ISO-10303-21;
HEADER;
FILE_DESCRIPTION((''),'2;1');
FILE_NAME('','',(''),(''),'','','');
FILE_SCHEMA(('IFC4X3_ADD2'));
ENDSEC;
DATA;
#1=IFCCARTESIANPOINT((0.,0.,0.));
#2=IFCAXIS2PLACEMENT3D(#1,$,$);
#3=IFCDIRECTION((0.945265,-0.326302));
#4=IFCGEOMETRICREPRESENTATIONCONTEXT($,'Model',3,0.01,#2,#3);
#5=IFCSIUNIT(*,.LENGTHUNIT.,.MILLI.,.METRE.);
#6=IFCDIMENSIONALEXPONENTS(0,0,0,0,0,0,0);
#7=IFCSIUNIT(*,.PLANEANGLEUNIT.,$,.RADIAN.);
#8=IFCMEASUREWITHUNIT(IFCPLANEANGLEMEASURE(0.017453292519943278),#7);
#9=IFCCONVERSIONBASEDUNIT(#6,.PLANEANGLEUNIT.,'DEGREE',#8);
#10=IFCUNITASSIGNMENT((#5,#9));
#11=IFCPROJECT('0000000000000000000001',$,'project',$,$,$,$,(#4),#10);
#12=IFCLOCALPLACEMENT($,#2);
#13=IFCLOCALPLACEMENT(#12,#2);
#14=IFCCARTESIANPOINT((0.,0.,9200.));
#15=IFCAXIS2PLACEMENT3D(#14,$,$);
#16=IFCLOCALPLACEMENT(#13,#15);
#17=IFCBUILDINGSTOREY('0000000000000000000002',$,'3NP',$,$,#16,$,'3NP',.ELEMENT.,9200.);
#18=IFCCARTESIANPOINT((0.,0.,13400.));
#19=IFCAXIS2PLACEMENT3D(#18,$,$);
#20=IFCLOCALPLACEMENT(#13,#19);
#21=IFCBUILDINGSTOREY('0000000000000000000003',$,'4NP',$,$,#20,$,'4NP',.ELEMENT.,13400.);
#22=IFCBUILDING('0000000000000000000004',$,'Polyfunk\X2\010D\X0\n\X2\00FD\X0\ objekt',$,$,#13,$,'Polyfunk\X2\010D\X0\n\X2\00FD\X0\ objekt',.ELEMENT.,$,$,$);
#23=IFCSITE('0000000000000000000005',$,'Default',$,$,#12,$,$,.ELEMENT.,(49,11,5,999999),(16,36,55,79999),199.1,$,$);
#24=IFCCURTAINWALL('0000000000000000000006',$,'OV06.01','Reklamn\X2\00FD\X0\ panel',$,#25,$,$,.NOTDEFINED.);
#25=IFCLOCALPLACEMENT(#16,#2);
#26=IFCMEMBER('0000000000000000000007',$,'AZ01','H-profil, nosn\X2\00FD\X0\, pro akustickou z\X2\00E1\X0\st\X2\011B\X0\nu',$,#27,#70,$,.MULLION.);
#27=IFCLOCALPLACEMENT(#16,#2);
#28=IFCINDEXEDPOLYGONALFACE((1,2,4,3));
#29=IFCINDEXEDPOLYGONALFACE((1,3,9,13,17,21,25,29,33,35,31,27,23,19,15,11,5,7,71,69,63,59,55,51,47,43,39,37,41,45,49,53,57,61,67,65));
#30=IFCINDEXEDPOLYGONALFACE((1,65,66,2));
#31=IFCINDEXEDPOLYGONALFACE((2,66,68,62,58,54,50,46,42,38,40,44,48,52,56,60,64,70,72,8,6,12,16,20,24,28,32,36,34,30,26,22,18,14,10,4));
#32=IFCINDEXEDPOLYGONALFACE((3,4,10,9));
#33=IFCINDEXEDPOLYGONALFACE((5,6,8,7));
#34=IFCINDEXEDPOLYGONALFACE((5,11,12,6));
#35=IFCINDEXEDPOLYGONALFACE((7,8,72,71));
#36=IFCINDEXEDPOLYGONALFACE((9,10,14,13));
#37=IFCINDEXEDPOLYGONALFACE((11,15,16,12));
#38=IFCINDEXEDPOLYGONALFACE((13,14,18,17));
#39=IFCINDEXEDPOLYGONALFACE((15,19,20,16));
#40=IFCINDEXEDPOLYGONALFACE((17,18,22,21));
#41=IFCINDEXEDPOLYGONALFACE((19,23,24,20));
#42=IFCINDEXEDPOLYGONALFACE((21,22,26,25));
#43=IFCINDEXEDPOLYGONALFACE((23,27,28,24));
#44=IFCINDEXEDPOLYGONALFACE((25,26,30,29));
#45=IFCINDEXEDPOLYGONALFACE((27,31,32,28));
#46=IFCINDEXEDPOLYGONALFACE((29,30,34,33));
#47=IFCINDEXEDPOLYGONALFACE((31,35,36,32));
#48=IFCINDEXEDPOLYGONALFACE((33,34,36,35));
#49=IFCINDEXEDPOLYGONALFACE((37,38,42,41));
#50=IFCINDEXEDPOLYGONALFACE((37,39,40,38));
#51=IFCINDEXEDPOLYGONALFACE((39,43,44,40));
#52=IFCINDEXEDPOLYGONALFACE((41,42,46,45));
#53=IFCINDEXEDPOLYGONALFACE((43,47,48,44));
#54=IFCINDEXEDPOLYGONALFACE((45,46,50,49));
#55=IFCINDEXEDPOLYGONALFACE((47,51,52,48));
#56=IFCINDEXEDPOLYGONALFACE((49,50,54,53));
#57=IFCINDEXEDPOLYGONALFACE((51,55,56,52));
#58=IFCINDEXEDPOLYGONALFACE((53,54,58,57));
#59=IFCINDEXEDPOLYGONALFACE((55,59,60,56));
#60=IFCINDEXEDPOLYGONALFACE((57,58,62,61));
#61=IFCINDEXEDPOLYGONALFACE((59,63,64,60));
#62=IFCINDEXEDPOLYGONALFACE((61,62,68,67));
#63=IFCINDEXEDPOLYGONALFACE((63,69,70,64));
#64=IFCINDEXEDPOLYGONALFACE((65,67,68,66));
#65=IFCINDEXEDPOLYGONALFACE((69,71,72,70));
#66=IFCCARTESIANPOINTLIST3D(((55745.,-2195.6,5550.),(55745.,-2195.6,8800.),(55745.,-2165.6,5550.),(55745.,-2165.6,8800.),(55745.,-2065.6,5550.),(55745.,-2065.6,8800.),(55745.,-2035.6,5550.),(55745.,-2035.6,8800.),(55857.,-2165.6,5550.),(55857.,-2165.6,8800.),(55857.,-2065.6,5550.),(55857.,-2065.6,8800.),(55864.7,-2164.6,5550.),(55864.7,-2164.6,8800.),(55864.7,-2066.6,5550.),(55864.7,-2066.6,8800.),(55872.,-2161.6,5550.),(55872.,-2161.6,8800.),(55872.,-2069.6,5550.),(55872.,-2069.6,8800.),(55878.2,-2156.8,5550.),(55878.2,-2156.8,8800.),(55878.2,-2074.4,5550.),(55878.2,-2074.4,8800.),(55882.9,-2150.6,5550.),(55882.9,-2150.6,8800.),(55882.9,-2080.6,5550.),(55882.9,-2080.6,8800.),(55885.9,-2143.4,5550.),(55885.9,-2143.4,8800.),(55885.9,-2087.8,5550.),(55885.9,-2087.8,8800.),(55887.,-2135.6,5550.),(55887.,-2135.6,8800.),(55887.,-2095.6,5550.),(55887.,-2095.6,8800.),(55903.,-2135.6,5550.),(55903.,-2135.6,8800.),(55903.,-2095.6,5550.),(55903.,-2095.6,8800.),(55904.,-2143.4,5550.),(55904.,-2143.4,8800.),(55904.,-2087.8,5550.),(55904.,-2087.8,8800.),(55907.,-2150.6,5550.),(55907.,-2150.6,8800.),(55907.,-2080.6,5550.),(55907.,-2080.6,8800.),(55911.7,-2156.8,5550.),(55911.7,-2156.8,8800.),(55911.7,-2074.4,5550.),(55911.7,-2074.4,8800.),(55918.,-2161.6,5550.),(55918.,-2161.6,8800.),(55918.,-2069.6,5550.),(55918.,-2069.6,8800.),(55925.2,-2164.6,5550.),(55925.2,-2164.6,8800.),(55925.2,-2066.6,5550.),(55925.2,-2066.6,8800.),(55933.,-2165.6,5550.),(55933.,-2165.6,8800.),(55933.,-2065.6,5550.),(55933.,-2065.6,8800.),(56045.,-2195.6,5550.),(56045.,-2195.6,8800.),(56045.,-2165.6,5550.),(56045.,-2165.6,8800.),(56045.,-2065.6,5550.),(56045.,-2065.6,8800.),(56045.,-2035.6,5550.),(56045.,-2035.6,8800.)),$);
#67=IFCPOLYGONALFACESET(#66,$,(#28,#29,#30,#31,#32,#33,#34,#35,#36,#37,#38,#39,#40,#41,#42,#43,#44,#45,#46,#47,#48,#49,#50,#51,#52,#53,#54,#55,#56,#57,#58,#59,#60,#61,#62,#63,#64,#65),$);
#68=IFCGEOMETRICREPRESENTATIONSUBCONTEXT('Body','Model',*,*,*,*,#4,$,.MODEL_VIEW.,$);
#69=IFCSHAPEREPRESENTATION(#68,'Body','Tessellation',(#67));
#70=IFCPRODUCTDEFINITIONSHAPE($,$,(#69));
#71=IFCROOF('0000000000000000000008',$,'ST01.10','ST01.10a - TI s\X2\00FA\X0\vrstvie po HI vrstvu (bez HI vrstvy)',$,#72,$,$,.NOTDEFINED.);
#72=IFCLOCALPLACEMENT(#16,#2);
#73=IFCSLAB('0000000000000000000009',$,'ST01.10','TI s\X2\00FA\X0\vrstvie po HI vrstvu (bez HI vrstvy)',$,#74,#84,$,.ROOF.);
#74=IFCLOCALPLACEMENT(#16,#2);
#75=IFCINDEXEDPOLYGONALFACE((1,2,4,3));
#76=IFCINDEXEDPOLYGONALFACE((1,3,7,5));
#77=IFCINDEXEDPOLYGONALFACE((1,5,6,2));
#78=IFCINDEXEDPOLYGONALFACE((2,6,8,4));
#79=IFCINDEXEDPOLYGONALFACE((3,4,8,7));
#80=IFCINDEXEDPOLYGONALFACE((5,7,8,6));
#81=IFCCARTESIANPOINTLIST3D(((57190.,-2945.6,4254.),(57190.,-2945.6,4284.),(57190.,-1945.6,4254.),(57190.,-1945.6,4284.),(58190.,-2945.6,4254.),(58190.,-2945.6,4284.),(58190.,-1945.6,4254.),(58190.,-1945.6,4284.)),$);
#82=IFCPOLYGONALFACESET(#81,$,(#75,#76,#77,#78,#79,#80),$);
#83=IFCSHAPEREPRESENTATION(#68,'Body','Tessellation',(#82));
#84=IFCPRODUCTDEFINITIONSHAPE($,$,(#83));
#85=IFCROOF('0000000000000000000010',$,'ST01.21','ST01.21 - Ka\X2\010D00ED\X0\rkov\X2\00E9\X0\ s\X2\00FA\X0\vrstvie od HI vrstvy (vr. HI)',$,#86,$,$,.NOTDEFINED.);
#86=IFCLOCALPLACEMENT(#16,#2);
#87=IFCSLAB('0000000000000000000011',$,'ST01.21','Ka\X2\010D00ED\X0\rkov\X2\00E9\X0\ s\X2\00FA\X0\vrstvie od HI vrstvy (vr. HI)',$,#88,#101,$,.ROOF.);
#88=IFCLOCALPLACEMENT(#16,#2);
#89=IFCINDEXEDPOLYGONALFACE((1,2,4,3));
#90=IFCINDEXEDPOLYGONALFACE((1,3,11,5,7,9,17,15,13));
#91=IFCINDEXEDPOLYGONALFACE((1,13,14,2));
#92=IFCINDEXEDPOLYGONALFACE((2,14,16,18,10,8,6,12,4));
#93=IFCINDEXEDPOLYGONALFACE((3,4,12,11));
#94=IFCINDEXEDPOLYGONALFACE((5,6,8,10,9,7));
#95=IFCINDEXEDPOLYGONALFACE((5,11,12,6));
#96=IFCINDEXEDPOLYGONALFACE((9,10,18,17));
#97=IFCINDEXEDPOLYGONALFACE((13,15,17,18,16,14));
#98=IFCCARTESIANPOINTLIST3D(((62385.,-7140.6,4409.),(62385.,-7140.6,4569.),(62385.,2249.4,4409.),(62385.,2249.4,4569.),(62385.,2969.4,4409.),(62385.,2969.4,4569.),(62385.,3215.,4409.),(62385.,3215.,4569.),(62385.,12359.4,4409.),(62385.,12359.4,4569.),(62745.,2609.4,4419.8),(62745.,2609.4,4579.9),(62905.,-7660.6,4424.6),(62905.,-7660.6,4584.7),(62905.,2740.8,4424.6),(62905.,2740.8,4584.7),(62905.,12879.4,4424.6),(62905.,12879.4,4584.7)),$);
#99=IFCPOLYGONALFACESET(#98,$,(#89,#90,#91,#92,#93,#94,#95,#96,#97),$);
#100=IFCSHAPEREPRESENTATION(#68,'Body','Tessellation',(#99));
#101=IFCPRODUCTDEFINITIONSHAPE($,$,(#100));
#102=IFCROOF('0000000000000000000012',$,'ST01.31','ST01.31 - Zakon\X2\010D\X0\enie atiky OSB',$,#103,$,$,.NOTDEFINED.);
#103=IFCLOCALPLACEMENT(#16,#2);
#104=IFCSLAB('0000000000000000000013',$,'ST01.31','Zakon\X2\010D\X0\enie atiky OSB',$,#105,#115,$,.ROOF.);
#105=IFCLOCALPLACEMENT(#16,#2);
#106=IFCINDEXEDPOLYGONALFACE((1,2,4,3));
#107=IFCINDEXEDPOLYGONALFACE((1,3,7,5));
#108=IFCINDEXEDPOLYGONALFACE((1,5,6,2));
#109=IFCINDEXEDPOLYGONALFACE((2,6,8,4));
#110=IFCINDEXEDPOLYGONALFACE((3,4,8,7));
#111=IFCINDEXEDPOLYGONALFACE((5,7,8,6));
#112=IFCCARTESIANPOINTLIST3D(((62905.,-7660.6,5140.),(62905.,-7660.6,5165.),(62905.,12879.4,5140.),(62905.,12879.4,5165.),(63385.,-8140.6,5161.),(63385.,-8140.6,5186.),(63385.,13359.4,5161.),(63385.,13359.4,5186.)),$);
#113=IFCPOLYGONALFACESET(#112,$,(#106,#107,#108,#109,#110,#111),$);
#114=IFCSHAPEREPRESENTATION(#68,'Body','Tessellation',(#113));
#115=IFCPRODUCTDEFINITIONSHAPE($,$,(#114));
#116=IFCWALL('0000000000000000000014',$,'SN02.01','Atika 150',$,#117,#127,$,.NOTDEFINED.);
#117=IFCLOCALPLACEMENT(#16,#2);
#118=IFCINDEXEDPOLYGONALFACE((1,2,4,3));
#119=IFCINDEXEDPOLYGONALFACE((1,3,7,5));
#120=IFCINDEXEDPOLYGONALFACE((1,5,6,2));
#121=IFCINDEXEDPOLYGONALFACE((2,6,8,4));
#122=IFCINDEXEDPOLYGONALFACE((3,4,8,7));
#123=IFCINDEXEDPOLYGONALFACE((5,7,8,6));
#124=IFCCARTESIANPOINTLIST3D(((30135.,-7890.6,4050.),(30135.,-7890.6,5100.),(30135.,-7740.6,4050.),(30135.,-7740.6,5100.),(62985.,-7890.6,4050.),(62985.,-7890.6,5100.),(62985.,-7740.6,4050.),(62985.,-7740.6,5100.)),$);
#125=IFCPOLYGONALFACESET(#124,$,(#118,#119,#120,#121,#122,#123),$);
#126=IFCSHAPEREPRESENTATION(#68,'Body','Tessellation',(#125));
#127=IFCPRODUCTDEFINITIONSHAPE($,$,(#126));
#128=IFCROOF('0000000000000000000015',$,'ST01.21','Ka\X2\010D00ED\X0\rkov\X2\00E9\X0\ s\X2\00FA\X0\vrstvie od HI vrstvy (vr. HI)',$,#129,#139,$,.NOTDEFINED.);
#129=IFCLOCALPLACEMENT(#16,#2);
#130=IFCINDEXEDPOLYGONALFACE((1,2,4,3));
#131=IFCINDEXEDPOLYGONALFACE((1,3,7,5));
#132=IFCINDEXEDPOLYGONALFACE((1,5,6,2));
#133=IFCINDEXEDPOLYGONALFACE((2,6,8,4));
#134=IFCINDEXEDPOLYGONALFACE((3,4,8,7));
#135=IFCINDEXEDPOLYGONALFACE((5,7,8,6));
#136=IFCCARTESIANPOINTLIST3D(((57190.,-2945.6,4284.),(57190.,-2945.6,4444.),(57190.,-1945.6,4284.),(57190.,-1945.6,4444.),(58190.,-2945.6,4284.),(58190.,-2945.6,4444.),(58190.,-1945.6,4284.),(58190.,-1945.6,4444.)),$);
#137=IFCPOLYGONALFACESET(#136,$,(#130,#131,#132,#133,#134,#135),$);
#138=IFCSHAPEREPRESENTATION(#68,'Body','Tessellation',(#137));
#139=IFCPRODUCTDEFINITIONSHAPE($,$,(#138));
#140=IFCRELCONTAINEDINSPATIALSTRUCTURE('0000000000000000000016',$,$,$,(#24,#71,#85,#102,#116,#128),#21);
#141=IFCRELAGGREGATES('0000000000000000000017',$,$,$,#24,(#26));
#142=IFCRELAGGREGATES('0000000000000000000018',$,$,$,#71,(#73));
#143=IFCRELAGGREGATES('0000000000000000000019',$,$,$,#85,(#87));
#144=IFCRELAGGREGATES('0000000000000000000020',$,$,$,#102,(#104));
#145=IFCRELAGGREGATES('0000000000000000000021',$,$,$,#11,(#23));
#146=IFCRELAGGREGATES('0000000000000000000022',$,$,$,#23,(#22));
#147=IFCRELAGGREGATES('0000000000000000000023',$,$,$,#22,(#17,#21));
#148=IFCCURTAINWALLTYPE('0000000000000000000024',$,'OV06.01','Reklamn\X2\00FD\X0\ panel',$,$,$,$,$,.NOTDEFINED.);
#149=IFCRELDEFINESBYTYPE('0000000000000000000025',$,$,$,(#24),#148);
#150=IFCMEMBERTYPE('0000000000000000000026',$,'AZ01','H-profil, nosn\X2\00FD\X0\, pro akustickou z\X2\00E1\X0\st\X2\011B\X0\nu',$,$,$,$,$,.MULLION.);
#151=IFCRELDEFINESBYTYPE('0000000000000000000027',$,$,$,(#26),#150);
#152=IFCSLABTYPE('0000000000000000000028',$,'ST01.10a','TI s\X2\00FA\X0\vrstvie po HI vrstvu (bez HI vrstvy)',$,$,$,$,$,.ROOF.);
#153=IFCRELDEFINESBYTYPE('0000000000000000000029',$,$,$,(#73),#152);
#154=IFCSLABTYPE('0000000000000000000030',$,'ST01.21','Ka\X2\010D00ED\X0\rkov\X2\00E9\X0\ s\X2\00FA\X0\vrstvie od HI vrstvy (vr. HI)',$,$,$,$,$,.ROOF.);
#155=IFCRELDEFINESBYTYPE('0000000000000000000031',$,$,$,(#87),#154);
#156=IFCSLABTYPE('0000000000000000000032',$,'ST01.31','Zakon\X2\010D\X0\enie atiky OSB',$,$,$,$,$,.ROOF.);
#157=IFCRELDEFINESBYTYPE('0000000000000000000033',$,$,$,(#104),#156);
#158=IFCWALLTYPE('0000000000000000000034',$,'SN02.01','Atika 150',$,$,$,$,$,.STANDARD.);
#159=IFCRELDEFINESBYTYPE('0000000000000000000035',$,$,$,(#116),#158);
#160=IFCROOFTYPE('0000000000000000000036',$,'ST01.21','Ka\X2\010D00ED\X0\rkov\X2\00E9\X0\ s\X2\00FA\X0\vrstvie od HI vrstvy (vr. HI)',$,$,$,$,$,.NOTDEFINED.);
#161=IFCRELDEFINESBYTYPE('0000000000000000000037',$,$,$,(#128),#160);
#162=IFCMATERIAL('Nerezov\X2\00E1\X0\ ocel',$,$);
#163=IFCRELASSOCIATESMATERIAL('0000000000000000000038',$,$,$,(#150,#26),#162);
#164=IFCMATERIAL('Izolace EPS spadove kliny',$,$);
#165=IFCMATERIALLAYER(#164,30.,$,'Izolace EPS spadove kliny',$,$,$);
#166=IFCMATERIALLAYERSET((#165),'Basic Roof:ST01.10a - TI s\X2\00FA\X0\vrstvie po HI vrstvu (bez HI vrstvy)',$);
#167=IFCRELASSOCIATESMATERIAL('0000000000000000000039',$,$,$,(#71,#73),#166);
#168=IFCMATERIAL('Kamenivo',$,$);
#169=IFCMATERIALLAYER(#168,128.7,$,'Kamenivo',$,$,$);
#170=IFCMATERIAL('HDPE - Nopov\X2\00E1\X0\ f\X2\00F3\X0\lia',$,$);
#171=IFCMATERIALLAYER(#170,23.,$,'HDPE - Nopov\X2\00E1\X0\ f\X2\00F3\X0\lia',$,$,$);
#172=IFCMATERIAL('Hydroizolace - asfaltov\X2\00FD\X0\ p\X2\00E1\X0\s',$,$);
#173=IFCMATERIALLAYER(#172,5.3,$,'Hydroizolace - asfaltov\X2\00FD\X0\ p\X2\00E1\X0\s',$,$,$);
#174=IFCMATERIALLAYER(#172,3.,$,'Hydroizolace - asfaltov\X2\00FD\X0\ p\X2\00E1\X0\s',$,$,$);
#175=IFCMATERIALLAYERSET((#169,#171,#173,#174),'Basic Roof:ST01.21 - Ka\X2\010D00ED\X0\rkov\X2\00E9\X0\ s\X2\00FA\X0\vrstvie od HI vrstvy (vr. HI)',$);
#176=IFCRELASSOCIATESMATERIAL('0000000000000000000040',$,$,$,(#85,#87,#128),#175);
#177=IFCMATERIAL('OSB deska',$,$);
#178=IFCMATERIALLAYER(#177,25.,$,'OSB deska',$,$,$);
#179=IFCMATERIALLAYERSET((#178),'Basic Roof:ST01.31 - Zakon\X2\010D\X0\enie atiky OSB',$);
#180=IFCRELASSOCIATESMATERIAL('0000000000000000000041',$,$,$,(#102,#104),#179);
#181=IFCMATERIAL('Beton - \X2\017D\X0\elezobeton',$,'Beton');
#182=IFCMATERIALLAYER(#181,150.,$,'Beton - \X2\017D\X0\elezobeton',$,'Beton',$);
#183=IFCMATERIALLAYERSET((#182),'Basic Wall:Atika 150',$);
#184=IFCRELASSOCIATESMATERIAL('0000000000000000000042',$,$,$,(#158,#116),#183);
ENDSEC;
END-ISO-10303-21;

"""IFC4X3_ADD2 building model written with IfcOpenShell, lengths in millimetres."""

from ifc_helpers import new_model, entity, si_unit, converted_unit, direction, frame, frame_2d, origin, origin_2d_with_axis, place, context, subcontext, project, spatial, polyline, circle_curve, parameter, trimmed, segment, composite_curve, rectangle, outline, extrude, source, transform, mapped, material, layer, layer_set, material_profile, profile_set, profile_usage, type_object, element, aggregate, save


model = new_model("IFC4X3_ADD2")

# Units and contexts
model_context = context("Model", 3, precision=0.01, world=origin(), true_north=direction((0.945265, -0.326302)))
body_context = subcontext(model_context, "Body", "Model", "MODEL_VIEW")
ifc_project = project(units=[si_unit("LENGTHUNIT", "METRE", prefix="MILLI"), converted_unit("PLANEANGLEUNIT", "DEGREE", entity("IfcPlaneAngleMeasure", 0.017453292519943278), si_unit("PLANEANGLEUNIT", "RADIAN"), dimensions=[0, 0, 0, 0, 0, 0, 0])], contexts=[model_context])

# Site, building, storey
site_placement = place(None, origin())
site = spatial("IfcSite", under=ifc_project, at=site_placement, Name="Default", CompositionType="ELEMENT", RefLatitude=(49, 11, 5, 999999), RefLongitude=(16, 36, 55, 79999), RefElevation=199.1)
building_placement = place(site_placement, origin())
building = spatial("IfcBuilding", under=site, at=building_placement, Name="Polyfunkčný objekt", LongName="Polyfunkčný objekt", CompositionType="ELEMENT")
storey_1_placement = place(building_placement, frame((0.0, 0.0, 9200.0)))
storey_1 = spatial("IfcBuildingStorey", under=building, at=storey_1_placement, Name="3NP", LongName="3NP", CompositionType="ELEMENT", Elevation=9200.0)

# Shared definitions
storey_2_placement = place(building_placement, frame((0.0, 0.0, 13400.0)))
storey_2 = spatial("IfcBuildingStorey", under=building, at=storey_2_placement, Name="4NP", LongName="4NP", CompositionType="ELEMENT", Elevation=13400.0)

# Curtain wall, member
ifc_material_1 = material(Name="Nerezová ocel")
ifc_material_profile_1 = material_profile(ifc_material_1, outline(composite_curve([segment(polyline([(50.0, -150.0), (80.0, -150.0)]), True, "CONTINUOUS"), segment(polyline([(80.0, -150.0), (80.0, 150.0)]), True, "CONTINUOUS"), segment(polyline([(80.0, 150.0), (50.0, 150.0)]), True, "CONTINUOUS"), segment(polyline([(50.0, 150.0), (50.0, 38.0)]), True, "CONTINUOUS"), segment(trimmed(circle_curve(frame_2d((20.0, 38.0), x_axis=(0.0, 1.0)), 30.0), [parameter(180.0)], [parameter(270.0)], True, "PARAMETER"), False, "CONTINUOUS"), segment(polyline([(20.0, 8.0), (-20.0, 8.0)]), True, "CONTINUOUS"), segment(trimmed(circle_curve(frame_2d((-20.0, 38.0), x_axis=(0.0, 1.0)), 30.0), [parameter(90.0)], [parameter(180.0)], True, "PARAMETER"), False, "CONTINUOUS"), segment(polyline([(-50.0, 38.0), (-50.0, 150.0)]), True, "CONTINUOUS"), segment(polyline([(-50.0, 150.0), (-80.0, 150.0)]), True, "CONTINUOUS"), segment(polyline([(-80.0, 150.0), (-80.0, -150.0)]), True, "CONTINUOUS"), segment(polyline([(-80.0, -150.0), (-50.0, -150.0)]), True, "CONTINUOUS"), segment(polyline([(-50.0, -150.0), (-50.0, -38.0)]), True, "CONTINUOUS"), segment(trimmed(circle_curve(frame_2d((-20.0, -38.0), x_axis=(0.0, 1.0)), 30.0), [parameter(0.0)], [parameter(90.0)], True, "PARAMETER"), False, "CONTINUOUS"), segment(polyline([(-20.0, -8.0), (20.0, -8.0)]), True, "CONTINUOUS"), segment(trimmed(circle_curve(frame_2d((20.0, -38.0), x_axis=(0.0, 1.0)), 30.0), [parameter(270.0)], [parameter(0.0)], True, "PARAMETER"), False, "CONTINUOUS"), segment(polyline([(50.0, -38.0), (50.0, -150.0)]), True, "CONTINUOUS")], self_intersect=False)), Name="Profil zástena")
ifc_profile_set_1 = profile_set([ifc_material_profile_1], Name="Profil zástena")
ifc_profile_usage_1 = profile_usage(ifc_profile_set_1)
member_type_1 = type_object("IfcMemberType", Name="AZ01", Description="H-profil, nosný, pro akustickou zástěnu", PredefinedType="MULLION", material=ifc_profile_set_1)
curtain_wall_type_1 = type_object("IfcCurtainWallType", Name="OV06.01", Description="Reklamný panel", PredefinedType="NOTDEFINED")
curtain_wall_1_placement = place(storey_2_placement, frame((0.0, 0.0, -13400.0)))
curtain_wall_1 = element("IfcCurtainWall", 1, at=curtain_wall_1_placement, inside=storey_2, type_object=curtain_wall_type_1, Name="OV06.01", Description="Reklamný panel", PredefinedType="NOTDEFINED")
shared_shape_1 = source(origin(), body_context, "Body", "SweptSolid", [
    extrude(outline(composite_curve([segment(polyline([(-150.0, -50.0), (-150.0, -80.0)]), True, "CONTINUOUS"), segment(polyline([(-150.0, -80.0), (150.0, -80.0)]), True, "CONTINUOUS"), segment(polyline([(150.0, -80.0), (150.0, -50.0)]), True, "CONTINUOUS"), segment(polyline([(150.0, -50.0), (38.0, -50.0)]), True, "CONTINUOUS"), segment(trimmed(circle_curve(frame_2d((38.0, -20.0), x_axis=(1.0, 0.0)), 30.0), [parameter(180.0)], [parameter(270.0)], True, "PARAMETER"), False, "CONTINUOUS"), segment(polyline([(8.0, -20.0), (8.0, 20.0)]), True, "CONTINUOUS"), segment(trimmed(circle_curve(frame_2d((38.0, 20.0), x_axis=(1.0, 0.0)), 30.0), [parameter(90.0)], [parameter(180.0)], True, "PARAMETER"), False, "CONTINUOUS"), segment(polyline([(38.0, 50.0), (150.0, 50.0)]), True, "CONTINUOUS"), segment(polyline([(150.0, 50.0), (150.0, 80.0)]), True, "CONTINUOUS"), segment(polyline([(150.0, 80.0), (-150.0, 80.0)]), True, "CONTINUOUS"), segment(polyline([(-150.0, 80.0), (-150.0, 50.0)]), True, "CONTINUOUS"), segment(polyline([(-150.0, 50.0), (-38.0, 50.0)]), True, "CONTINUOUS"), segment(trimmed(circle_curve(frame_2d((-38.0, 20.0), x_axis=(1.0, 0.0)), 30.0), [parameter(0.0)], [parameter(90.0)], True, "PARAMETER"), False, "CONTINUOUS"), segment(polyline([(-8.0, 20.0), (-8.0, -20.0)]), True, "CONTINUOUS"), segment(trimmed(circle_curve(frame_2d((-38.0, -20.0), x_axis=(1.0, 0.0)), 30.0), [parameter(270.0)], [parameter(0.0)], True, "PARAMETER"), False, "CONTINUOUS"), segment(polyline([(-38.0, -50.0), (-150.0, -50.0)]), True, "CONTINUOUS")], self_intersect=False)), frame((-150.0, 0.0, -3250.0), z_axis=(0.0, 0.0, -1.0), x_axis=(1.0, 0.0, 0.0)), (0.0, 0.0, -1.0), 3250.0),
])
member_1_placement = place(curtain_wall_1_placement, frame((56045.0, -2115.6, 14750.0), z_axis=(0.0, 0.0, -1.0), x_axis=(1.0, 0.0, 0.0)))
member_1 = element("IfcMember", 2, at=member_1_placement, type_object=member_type_1, material=ifc_profile_usage_1, Name="AZ01", Description="H-profil, nosný, pro akustickou zástěnu", PredefinedType="MULLION", context=body_context, shape_type="MappedRepresentation", body=[
    mapped(shared_shape_1, transform((0.0, 0.0, 0.0), scale=1.0)),
])
aggregate(curtain_wall_1, [member_1])

# Roofs, slabs
ifc_material_2 = material(Name="HDPE - Nopová fólia")
ifc_material_3 = material(Name="Hydroizolace - asfaltový pás")
ifc_material_4 = material(Name="Izolace EPS spadove kliny")
ifc_layer_1 = layer(ifc_material_4, 30.0, Name="Izolace EPS spadove kliny")
ifc_layer_set_1 = layer_set([ifc_layer_1], Name="Basic Roof:ST01.10a - TI súvrstvie po HI vrstvu (bez HI vrstvy)")
roof_1_placement = place(storey_2_placement, frame((57190.0, -2945.6, 54.0)))
roof_1 = element("IfcRoof", 3, at=roof_1_placement, inside=storey_2, material=ifc_layer_set_1, Name="ST01.10", Description="ST01.10a - TI súvrstvie po HI vrstvu (bez HI vrstvy)", PredefinedType="NOTDEFINED")
slab_type_1 = type_object("IfcSlabType", Name="ST01.10a", Description="TI súvrstvie po HI vrstvu (bez HI vrstvy)", PredefinedType="ROOF")
slab_1_placement = place(roof_1_placement, origin())
slab_1 = element("IfcSlab", 4, at=slab_1_placement, type_object=slab_type_1, material=ifc_layer_set_1, Name="ST01.10", Description="TI súvrstvie po HI vrstvu (bez HI vrstvy)", PredefinedType="ROOF", context=body_context, shape_type="SweptSolid", body=[
    extrude(rectangle(XDim=1000.0, YDim=1000.0, at=frame_2d((0.0, 0.0), x_axis=(-1.0, 0.0))), frame((500.0, 500.0, 0.0)), (0.0, 0.0, 1.0), 30.0),
])
aggregate(roof_1, [slab_1])
ifc_material_5 = material(Name="Kamenivo")
ifc_layer_2 = layer(ifc_material_5, 128.7, Name="Kamenivo")
ifc_layer_3 = layer(ifc_material_2, 23.0, Name="HDPE - Nopová fólia")
ifc_layer_4 = layer(ifc_material_3, 5.3, Name="Hydroizolace - asfaltový pás")
ifc_layer_5 = layer(ifc_material_3, 3.0, Name="Hydroizolace - asfaltový pás")
ifc_layer_set_2 = layer_set([ifc_layer_2, ifc_layer_3, ifc_layer_4, ifc_layer_5], Name="Basic Roof:ST01.21 - Kačírkové súvrstvie od HI vrstvy (vr. HI)")
roof_2_placement = place(storey_2_placement, frame((62385.0, -7660.6, 209.0)))
roof_2 = element("IfcRoof", 5, at=roof_2_placement, inside=storey_2, material=ifc_layer_set_2, Name="ST01.21", Description="ST01.21 - Kačírkové súvrstvie od HI vrstvy (vr. HI)", PredefinedType="NOTDEFINED")
slab_type_2 = type_object("IfcSlabType", Name="ST01.21", Description="Kačírkové súvrstvie od HI vrstvy (vr. HI)", PredefinedType="ROOF")
slab_2_placement = place(roof_2_placement, origin())
slab_2 = element("IfcSlab", 6, at=slab_2_placement, type_object=slab_type_2, material=ifc_layer_set_2, Name="ST01.21", Description="Kačírkové súvrstvie od HI vrstvy (vr. HI)", PredefinedType="ROOF", context=body_context, shape_type="SweptSolid", body=[
    extrude(outline(polyline([(-260.1, -9750.0), (260.1, -10270.0), (260.1, 131.4), (260.1, 10270.0), (-260.1, 9750.0), (-260.1, 605.6), (-260.1, 360.0), (100.0, 0.0), (-260.1, -360.0), (-260.1, -9750.0)])), frame((260.0, 10270.0, 7.8), z_axis=(-0.030015, 0.0, 0.999549), x_axis=(0.999549, 0.0, 0.030015)), (0.030015, 0.0, 0.999549), 160.1),
])
aggregate(roof_2, [slab_2])
ifc_material_6 = material(Name="OSB deska")
ifc_layer_6 = layer(ifc_material_6, 25.0, Name="OSB deska")
ifc_layer_set_3 = layer_set([ifc_layer_6], Name="Basic Roof:ST01.31 - Zakončenie atiky OSB")
roof_3_placement = place(storey_2_placement, frame((62905.0, -8140.6, 940.0)))
roof_3 = element("IfcRoof", 7, at=roof_3_placement, inside=storey_2, material=ifc_layer_set_3, Name="ST01.31", Description="ST01.31 - Zakončenie atiky OSB", PredefinedType="NOTDEFINED")
slab_type_3 = type_object("IfcSlabType", Name="ST01.31", Description="Zakončenie atiky OSB", PredefinedType="ROOF")
slab_3_placement = place(roof_3_placement, origin())
slab_3 = element("IfcSlab", 8, at=slab_3_placement, type_object=slab_type_3, material=ifc_layer_set_3, Name="ST01.31", Description="Zakončenie atiky OSB", PredefinedType="ROOF", context=body_context, shape_type="SweptSolid", body=[
    extrude(outline(polyline([(-240.2, 10270.0), (-240.2, -10270.0), (240.2, -10750.0), (240.2, 10750.0), (-240.2, 10270.0)])), frame((240.0, 10750.0, 10.5), z_axis=(-0.043619, 0.0, 0.999048), x_axis=(0.999048, 0.0, 0.043619)), (0.043619, 0.0, 0.999048), 25.0),
])
aggregate(roof_3, [slab_3])

# Wall
ifc_material_7 = material(Name="Beton - Železobeton", Category="Beton")
ifc_layer_7 = layer(ifc_material_7, 150.0, Name="Beton - Železobeton", Category="Beton")
ifc_layer_set_4 = layer_set([ifc_layer_7], Name="Basic Wall:Atika 150")
wall_type = type_object("IfcWallType", Name="SN02.01", Description="Atika 150", PredefinedType="STANDARD", material=ifc_layer_set_4)
wall_placement = place(storey_2_placement, frame((62985.0, -7815.6, -150.0), z_axis=(0.0, 0.0, 1.0), x_axis=(-1.0, 0.0, 0.0)))
element("IfcWall", 9, at=wall_placement, inside=storey_2, type_object=wall_type, material=ifc_layer_set_4, Name="SN02.01", Description="Atika 150", PredefinedType="NOTDEFINED", context=body_context, shape_type="SweptSolid", body=[
    extrude(rectangle(XDim=32850.0, YDim=150.0, at=frame_2d((16425.0, 0.0), x_axis=(-1.0, 0.0))), origin(), (0.0, 0.0, 1.0), 1050.0),
])

# Roof
roof_type = type_object("IfcRoofType", Name="ST01.21", Description="Kačírkové súvrstvie od HI vrstvy (vr. HI)", PredefinedType="NOTDEFINED")
roof_4_placement = place(storey_2_placement, frame((57190.0, -2945.6, 84.0)))
element("IfcRoof", 10, at=roof_4_placement, inside=storey_2, type_object=roof_type, material=ifc_layer_set_2, Name="ST01.21", Description="Kačírkové súvrstvie od HI vrstvy (vr. HI)", PredefinedType="NOTDEFINED", context=body_context, shape_type="SweptSolid", body=[
    extrude(rectangle(XDim=1000.0, YDim=1000.0, at=origin_2d_with_axis()), frame((500.0, 500.0, 0.0), z_axis=(0.0, 0.0, 1.0), x_axis=(0.0, -1.0, 0.0)), (0.0, 0.0, 1.0), 160.0),
])

save(model, "model.ifc")
